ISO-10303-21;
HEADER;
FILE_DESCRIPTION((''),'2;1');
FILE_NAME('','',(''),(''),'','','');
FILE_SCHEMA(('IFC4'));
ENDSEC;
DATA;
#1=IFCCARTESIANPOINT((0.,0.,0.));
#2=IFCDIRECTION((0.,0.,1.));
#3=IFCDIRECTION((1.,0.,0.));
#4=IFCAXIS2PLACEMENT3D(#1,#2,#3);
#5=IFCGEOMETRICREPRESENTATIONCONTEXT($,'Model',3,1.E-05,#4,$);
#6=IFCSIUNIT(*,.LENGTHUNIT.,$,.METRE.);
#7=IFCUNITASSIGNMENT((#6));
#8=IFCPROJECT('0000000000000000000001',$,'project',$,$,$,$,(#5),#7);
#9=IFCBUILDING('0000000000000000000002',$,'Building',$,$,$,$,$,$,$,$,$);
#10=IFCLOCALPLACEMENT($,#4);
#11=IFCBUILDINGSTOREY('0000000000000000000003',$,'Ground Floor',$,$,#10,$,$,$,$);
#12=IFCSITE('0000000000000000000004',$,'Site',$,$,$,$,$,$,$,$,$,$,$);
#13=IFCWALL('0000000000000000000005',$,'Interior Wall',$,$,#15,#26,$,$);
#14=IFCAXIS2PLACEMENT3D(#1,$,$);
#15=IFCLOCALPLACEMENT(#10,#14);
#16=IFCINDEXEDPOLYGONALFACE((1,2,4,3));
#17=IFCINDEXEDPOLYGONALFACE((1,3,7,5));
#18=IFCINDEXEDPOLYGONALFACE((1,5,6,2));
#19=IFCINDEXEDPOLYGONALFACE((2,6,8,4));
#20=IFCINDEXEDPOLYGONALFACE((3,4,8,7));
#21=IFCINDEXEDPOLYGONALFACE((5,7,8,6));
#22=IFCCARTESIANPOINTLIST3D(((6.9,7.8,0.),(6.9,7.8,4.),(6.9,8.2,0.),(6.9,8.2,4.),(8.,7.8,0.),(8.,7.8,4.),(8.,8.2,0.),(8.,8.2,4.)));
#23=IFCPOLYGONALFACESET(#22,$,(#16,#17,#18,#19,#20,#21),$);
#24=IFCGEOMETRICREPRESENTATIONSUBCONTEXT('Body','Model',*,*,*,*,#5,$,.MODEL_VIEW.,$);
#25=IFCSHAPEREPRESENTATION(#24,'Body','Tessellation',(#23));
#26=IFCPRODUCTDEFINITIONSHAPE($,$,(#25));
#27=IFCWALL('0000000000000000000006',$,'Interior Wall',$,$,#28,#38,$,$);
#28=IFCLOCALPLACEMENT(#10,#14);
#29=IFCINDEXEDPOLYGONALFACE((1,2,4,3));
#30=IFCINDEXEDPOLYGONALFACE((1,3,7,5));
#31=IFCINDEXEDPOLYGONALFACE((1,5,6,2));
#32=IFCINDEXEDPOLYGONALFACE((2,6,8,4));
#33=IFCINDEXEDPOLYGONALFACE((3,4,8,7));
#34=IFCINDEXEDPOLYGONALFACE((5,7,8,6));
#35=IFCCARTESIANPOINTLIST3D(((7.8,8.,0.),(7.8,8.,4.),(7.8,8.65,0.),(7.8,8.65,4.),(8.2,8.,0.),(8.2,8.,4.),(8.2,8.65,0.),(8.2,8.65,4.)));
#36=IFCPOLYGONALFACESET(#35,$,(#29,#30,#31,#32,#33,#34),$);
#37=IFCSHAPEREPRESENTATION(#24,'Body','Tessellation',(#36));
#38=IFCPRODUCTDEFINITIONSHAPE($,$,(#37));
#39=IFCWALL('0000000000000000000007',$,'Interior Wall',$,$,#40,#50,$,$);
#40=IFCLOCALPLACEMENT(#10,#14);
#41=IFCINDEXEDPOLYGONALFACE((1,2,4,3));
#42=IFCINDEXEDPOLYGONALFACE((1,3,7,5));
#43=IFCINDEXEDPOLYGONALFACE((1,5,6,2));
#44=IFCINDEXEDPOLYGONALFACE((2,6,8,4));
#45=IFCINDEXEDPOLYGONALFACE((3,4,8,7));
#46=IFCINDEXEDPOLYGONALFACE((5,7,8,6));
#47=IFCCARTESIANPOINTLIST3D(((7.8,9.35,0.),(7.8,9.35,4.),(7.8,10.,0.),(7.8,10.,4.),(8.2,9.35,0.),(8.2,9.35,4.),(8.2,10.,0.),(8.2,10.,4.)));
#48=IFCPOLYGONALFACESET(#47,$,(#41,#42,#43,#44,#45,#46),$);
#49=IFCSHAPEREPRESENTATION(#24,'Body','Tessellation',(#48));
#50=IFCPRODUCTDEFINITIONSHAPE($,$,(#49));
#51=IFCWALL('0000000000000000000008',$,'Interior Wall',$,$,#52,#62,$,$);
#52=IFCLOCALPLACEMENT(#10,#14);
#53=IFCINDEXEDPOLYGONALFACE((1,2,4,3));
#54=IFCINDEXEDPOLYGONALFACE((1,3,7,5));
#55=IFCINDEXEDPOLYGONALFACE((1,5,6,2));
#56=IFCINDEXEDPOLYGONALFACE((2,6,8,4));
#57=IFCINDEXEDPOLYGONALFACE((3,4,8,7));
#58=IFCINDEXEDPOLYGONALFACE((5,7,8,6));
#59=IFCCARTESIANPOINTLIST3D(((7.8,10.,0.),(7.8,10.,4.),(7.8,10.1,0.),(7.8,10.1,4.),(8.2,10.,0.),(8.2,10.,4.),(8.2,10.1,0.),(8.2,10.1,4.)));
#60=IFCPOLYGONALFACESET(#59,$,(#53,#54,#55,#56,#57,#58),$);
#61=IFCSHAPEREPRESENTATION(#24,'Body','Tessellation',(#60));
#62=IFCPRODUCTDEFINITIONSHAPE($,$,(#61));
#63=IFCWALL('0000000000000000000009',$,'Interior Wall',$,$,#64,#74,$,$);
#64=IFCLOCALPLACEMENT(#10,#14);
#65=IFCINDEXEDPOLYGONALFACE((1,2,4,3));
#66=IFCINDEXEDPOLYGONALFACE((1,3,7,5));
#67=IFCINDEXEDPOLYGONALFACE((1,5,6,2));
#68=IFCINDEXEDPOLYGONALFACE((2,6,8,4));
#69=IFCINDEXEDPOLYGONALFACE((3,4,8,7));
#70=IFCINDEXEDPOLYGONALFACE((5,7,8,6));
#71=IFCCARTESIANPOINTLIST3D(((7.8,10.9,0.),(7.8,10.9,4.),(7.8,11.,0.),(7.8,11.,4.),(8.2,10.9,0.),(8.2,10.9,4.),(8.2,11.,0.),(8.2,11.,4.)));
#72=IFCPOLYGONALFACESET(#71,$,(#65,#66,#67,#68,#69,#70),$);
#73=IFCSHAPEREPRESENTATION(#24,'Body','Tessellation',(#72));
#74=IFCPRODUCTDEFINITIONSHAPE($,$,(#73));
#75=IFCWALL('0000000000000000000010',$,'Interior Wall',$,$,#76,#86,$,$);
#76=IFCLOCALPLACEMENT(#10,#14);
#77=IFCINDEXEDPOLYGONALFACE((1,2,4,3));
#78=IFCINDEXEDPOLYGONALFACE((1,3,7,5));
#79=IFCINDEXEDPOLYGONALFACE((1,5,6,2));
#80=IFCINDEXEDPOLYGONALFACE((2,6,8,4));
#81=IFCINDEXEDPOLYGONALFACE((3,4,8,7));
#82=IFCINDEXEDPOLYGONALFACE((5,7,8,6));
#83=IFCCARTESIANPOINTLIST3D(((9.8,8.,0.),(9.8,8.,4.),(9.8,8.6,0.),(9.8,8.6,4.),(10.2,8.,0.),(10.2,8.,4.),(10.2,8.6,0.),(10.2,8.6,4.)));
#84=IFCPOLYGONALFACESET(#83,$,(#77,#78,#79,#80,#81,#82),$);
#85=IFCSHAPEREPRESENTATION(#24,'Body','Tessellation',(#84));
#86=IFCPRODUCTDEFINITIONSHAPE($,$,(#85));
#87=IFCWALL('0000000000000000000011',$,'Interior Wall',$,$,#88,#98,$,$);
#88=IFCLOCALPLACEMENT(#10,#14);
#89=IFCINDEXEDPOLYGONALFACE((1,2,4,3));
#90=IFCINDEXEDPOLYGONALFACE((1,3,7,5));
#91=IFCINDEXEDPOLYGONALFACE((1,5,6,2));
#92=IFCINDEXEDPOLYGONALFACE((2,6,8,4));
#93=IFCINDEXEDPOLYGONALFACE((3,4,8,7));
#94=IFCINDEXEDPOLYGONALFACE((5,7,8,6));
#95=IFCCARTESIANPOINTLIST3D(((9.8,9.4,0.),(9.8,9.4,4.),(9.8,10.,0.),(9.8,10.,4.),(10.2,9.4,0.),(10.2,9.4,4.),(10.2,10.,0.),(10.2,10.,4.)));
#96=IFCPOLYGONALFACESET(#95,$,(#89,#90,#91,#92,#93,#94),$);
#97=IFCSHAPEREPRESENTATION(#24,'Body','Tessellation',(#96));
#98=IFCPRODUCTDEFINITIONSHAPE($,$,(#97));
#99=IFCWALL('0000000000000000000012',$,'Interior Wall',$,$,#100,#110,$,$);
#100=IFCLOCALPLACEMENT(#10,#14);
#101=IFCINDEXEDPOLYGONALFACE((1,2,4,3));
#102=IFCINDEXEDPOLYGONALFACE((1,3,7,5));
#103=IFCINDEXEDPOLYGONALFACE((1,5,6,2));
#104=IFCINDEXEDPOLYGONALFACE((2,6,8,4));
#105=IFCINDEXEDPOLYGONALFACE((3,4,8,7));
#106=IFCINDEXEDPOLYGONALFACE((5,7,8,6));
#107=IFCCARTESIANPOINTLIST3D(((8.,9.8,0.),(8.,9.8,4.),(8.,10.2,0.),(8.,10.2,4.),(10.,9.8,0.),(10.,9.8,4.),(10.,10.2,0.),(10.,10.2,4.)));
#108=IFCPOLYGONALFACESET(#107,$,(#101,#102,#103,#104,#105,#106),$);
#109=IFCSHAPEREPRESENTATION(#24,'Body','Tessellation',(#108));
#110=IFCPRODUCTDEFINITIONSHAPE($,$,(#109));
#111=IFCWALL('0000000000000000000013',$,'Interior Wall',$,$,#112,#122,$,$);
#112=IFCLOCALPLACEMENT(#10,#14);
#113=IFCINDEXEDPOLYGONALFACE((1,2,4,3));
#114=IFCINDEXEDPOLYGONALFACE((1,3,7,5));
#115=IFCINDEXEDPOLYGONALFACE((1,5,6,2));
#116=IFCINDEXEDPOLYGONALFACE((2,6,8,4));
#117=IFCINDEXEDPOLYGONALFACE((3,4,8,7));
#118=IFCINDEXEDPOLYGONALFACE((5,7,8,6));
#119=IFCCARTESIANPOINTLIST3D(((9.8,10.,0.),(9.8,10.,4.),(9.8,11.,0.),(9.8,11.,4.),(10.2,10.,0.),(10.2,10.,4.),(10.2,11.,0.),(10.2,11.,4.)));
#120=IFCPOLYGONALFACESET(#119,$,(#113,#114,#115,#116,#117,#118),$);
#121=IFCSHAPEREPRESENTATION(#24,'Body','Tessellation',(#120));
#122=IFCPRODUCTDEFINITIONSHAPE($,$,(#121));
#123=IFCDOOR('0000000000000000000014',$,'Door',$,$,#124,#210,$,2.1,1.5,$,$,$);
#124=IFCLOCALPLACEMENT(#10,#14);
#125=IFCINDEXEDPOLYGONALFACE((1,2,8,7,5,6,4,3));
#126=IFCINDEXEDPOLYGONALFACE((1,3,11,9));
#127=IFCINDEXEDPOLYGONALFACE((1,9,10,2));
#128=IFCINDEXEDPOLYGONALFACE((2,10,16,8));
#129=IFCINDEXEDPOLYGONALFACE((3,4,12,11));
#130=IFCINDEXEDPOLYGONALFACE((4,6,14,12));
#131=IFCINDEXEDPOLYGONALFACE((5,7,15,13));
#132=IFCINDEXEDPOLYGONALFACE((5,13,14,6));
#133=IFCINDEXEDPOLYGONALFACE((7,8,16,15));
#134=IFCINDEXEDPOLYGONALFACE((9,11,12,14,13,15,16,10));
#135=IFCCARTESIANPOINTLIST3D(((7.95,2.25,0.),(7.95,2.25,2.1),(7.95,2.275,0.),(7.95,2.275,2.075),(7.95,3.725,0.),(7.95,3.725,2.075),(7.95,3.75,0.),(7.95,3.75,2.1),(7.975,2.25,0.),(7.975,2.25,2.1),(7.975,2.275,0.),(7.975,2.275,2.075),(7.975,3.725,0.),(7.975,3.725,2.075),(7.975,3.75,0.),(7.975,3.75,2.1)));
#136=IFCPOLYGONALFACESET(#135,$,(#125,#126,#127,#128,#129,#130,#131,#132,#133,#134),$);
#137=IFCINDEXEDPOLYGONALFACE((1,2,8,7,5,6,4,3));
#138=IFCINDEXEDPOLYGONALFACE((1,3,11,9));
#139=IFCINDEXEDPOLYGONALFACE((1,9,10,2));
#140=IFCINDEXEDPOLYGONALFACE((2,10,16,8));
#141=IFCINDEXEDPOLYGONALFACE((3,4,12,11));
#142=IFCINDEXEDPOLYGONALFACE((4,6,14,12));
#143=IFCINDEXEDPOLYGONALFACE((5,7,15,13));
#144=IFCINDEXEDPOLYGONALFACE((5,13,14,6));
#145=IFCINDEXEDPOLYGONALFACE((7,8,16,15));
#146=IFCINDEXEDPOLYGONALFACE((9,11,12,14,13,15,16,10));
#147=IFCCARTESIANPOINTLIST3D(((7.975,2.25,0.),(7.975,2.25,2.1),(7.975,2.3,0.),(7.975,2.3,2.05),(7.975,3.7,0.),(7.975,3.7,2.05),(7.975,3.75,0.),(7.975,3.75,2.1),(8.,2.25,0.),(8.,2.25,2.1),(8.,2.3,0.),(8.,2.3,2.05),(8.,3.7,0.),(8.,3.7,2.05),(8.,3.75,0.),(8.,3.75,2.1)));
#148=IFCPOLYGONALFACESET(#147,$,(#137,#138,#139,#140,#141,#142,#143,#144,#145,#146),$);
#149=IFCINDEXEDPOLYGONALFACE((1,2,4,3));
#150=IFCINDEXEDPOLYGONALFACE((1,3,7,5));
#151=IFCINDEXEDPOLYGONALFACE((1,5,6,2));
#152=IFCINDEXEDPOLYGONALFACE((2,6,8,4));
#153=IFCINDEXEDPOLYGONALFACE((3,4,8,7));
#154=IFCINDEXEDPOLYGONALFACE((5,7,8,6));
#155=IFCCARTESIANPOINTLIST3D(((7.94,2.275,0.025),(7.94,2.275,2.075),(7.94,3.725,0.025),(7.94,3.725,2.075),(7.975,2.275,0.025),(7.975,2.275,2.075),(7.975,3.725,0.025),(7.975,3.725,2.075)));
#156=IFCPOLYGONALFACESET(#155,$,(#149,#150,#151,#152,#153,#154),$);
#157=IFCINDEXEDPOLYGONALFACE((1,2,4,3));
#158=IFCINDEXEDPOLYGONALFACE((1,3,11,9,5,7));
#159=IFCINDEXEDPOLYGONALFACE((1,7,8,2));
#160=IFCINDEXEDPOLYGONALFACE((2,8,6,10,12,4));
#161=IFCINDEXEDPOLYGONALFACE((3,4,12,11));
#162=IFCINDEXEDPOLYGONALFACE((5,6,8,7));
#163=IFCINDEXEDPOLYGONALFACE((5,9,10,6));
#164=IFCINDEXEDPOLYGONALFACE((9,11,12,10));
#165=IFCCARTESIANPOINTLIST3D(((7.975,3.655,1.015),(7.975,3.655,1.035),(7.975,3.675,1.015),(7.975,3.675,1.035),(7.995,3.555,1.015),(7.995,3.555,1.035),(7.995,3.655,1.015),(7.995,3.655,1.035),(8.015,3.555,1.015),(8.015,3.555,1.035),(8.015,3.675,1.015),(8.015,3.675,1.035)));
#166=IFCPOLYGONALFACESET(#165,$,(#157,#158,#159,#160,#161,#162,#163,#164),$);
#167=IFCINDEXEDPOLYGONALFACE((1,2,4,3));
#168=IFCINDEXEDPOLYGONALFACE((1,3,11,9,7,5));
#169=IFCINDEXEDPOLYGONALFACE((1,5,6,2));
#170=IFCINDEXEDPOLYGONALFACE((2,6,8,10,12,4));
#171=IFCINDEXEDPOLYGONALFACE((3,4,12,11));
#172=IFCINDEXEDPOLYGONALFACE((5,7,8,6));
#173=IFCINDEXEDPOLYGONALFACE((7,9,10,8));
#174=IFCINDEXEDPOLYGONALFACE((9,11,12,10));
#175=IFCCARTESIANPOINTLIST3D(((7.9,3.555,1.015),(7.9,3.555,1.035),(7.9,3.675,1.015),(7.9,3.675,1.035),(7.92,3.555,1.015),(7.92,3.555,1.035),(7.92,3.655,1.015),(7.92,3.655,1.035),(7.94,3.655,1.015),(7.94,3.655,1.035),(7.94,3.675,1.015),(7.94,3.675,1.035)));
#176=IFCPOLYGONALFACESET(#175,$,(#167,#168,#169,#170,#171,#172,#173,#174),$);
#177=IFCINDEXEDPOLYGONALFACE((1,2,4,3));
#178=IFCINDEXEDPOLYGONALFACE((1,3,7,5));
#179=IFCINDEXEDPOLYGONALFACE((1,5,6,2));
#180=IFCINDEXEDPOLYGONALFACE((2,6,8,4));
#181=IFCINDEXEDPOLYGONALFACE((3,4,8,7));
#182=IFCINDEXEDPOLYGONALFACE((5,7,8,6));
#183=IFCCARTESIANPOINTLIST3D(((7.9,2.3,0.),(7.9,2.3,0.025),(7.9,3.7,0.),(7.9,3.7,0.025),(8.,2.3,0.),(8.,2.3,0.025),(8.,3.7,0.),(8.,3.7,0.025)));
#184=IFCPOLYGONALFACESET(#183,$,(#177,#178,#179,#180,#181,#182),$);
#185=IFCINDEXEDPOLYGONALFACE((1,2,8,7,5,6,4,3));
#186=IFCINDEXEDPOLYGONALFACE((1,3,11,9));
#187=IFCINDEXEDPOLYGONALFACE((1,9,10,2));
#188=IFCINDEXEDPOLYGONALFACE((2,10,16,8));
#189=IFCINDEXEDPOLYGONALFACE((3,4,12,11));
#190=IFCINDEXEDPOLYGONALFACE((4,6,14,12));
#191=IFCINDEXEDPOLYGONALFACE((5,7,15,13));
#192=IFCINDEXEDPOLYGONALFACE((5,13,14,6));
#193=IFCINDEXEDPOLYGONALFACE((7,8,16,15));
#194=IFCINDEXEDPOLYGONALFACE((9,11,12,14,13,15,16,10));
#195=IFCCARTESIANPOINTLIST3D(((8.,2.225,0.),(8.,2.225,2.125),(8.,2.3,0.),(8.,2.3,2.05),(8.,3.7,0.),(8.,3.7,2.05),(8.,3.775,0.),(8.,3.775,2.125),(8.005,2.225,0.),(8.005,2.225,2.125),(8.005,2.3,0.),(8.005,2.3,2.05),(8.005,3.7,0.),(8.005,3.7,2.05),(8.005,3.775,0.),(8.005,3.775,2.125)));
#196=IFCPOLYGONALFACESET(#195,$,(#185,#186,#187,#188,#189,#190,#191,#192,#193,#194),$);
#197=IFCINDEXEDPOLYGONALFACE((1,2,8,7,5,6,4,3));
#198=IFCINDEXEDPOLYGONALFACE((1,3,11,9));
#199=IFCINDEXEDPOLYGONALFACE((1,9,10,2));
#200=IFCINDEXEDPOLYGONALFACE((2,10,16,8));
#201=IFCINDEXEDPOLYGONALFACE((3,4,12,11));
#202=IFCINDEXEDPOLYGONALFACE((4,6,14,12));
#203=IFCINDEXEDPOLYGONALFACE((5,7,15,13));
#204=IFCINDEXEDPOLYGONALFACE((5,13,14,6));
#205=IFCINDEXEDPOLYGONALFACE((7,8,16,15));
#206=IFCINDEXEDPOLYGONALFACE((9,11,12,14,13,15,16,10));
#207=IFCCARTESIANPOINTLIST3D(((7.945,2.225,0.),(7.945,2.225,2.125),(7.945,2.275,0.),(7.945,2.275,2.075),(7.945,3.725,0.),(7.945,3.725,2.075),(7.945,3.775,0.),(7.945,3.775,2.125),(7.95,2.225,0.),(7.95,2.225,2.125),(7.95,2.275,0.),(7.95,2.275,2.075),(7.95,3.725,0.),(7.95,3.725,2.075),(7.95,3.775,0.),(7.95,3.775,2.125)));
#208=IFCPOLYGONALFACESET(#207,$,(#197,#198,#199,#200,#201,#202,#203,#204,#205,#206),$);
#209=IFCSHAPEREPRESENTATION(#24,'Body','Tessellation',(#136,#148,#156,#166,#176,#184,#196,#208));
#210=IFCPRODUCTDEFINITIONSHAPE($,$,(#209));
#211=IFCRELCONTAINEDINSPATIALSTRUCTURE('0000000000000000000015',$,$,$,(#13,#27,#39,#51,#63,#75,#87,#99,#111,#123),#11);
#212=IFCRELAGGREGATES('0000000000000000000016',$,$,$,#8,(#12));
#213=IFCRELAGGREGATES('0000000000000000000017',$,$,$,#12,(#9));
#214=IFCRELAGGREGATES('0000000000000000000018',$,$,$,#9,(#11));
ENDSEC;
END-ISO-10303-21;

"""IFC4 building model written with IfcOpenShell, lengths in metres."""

from ifc_helpers import new_model, si_unit, frame, origin_with_axes, place, context, subcontext, project, spatial, line, indexed_curve, outline, extrude, element, save


model = new_model("IFC4")

# Units and contexts
model_context = context("Model", 3, precision=1e-05, world=origin_with_axes())
body_context = subcontext(model_context, "Body", "Model", "MODEL_VIEW")
ifc_project = project(units=[si_unit("LENGTHUNIT", "METRE")], contexts=[model_context])

# Site, building, storey
site = spatial("IfcSite", under=ifc_project, Name="Site")
building = spatial("IfcBuilding", under=site, Name="Building")
storey_placement = place(None, origin_with_axes())
storey = spatial("IfcBuildingStorey", under=building, at=storey_placement, Name="Ground Floor")

# Walls
wall_1_placement = place(storey_placement, frame((8.0, 8.0, 0.0), z_axis=(0.0, 0.0, 1.0), x_axis=(-1.0, 0.0, 0.0)))
element("IfcWall", 1, at=wall_1_placement, inside=storey, Name="Interior Wall", context=body_context, shape_type="SweptSolid", body=[
    extrude(outline(indexed_curve([(0.0, 0.0), (0.0, 0.4), (1.1, 0.4), (1.1, 0.0), (0.0, 0.0)], self_intersect=False)), frame((0.0, -0.2, 0.0), z_axis=(0.0, 0.0, 1.0), x_axis=(1.0, 0.0, 0.0)), (0.0, 0.0, 1.0), 4.0),
])
for number, where, z_axis, x_axis, name in (
    (2, (8.0, 8.0, 0.0), (0.0, 0.0, 1.0), (0.0, 1.0, 0.0), "Interior Wall"),
    (3, (8.0, 9.35, 0.0), (0.0, 0.0, 1.0), (0.0, 1.0, 0.0), "Interior Wall"),
):
    element("IfcWall", number, at=place(storey_placement, frame(where, z_axis=z_axis, x_axis=x_axis)), inside=storey, Name=name, context=body_context, shape_type="SweptSolid", body=[
        extrude(outline(indexed_curve([(0.0, 0.0), (0.0, 0.4), (0.65, 0.4), (0.65, 0.0), (0.0, 0.0)], self_intersect=False)), frame((0.0, -0.2, 0.0), z_axis=(0.0, 0.0, 1.0), x_axis=(1.0, 0.0, 0.0)), (0.0, 0.0, 1.0), 4.0),
    ])
for number, where, z_axis, x_axis, name in (
    (4, (8.0, 10.0, 0.0), (0.0, 0.0, 1.0), (0.0, 1.0, 0.0), "Interior Wall"),
    (5, (8.0, 10.9, 0.0), (0.0, 0.0, 1.0), (0.0, 1.0, 0.0), "Interior Wall"),
):
    element("IfcWall", number, at=place(storey_placement, frame(where, z_axis=z_axis, x_axis=x_axis)), inside=storey, Name=name, context=body_context, shape_type="SweptSolid", body=[
        extrude(outline(indexed_curve([(0.0, 0.0), (0.0, 0.4), (0.1, 0.4), (0.1, 0.0), (0.0, 0.0)], self_intersect=False)), frame((0.0, -0.2, 0.0), z_axis=(0.0, 0.0, 1.0), x_axis=(1.0, 0.0, 0.0)), (0.0, 0.0, 1.0), 4.0),
    ])
for number, where, z_axis, x_axis, name in (
    (6, (10.0, 8.0, 0.0), (0.0, 0.0, 1.0), (0.0, 1.0, 0.0), "Interior Wall"),
    (7, (10.0, 9.4, 0.0), (0.0, 0.0, 1.0), (0.0, 1.0, 0.0), "Interior Wall"),
):
    element("IfcWall", number, at=place(storey_placement, frame(where, z_axis=z_axis, x_axis=x_axis)), inside=storey, Name=name, context=body_context, shape_type="SweptSolid", body=[
        extrude(outline(indexed_curve([(0.0, 0.0), (0.0, 0.4), (0.6, 0.4), (0.6, 0.0), (0.0, 0.0)], self_intersect=False)), frame((0.0, -0.2, 0.0), z_axis=(0.0, 0.0, 1.0), x_axis=(1.0, 0.0, 0.0)), (0.0, 0.0, 1.0), 4.0),
    ])
wall_2_placement = place(storey_placement, frame((10.0, 10.0, 0.0), z_axis=(0.0, 0.0, 1.0), x_axis=(-1.0, 0.0, 0.0)))
element("IfcWall", 8, at=wall_2_placement, inside=storey, Name="Interior Wall", context=body_context, shape_type="SweptSolid", body=[
    extrude(outline(indexed_curve([(0.0, 0.0), (0.0, 0.4), (2.0, 0.4), (2.0, 0.0), (0.0, 0.0)], self_intersect=False)), frame((0.0, -0.2, 0.0), z_axis=(0.0, 0.0, 1.0), x_axis=(1.0, 0.0, 0.0)), (0.0, 0.0, 1.0), 4.0),
])
wall_3_placement = place(storey_placement, frame((10.0, 11.0, 0.0), z_axis=(0.0, 0.0, 1.0), x_axis=(0.0, -1.0, 0.0)))
element("IfcWall", 9, at=wall_3_placement, inside=storey, Name="Interior Wall", context=body_context, shape_type="SweptSolid", body=[
    extrude(outline(indexed_curve([(0.0, 0.0), (0.0, 0.4), (1.0, 0.4), (1.0, 0.0), (0.0, 0.0)], self_intersect=False)), frame((0.0, -0.2, 0.0), z_axis=(0.0, 0.0, 1.0), x_axis=(1.0, 0.0, 0.0)), (0.0, 0.0, 1.0), 4.0),
])

# Door
door_1_placement = place(storey_placement, frame((8.0, 2.25, 0.0), z_axis=(0.0, 0.0, 1.0), x_axis=(0.0, 1.0, 0.0)))
element("IfcDoor", 10, at=door_1_placement, inside=storey, Name="Door", OverallHeight=2.1, OverallWidth=1.5, context=body_context, shape_type="SweptSolid", body=[
    extrude(outline(indexed_curve([(0.0, 0.0), (0.0, 2.1), (1.5, 2.1), (1.5, 0.0), (1.475, 0.0), (1.475, 2.075), (0.025, 2.075), (0.025, 0.0)], segments=[line(1, 2, 3, 4, 5, 6, 7, 8, 1)])), frame((0.0, 0.025, 0.0), z_axis=(0.0, -1.0, 0.0), x_axis=(1.0, 0.0, 0.0)), (0.0, 0.0, -1.0), 0.025),
    extrude(outline(indexed_curve([(0.0, 0.0), (0.0, 2.1), (1.5, 2.1), (1.5, 0.0), (1.45, 0.0), (1.45, 2.05), (0.05, 2.05), (0.05, 0.0)], segments=[line(1, 2, 3, 4, 5, 6, 7, 8, 1)])), frame((0.0, 0.0, 0.0), z_axis=(0.0, -1.0, 0.0), x_axis=(1.0, 0.0, 0.0)), (0.0, 0.0, -1.0), 0.025),
    extrude(outline(indexed_curve([(0.0, 0.0), (1.45, 0.0), (1.45, 0.035), (0.0, 0.035)], segments=[line(1, 2, 3, 4, 1)])), frame((0.025, 0.025, 0.025), z_axis=(0.0, 0.0, 1.0), x_axis=(1.0, 0.0, 0.0)), (0.0, 0.0, 1.0), 2.05),
    extrude(outline(indexed_curve([(0.0, 0.0), (0.0, -0.04), (-0.12, -0.04), (-0.12, -0.02), (-0.02, -0.02), (-0.02, 0.0)], segments=[line(1, 2, 3, 4, 5, 6, 1)])), frame((1.425, 0.025, 1.015), z_axis=(0.0, 0.0, 1.0), x_axis=(1.0, 0.0, 0.0)), (0.0, 0.0, 1.0), 0.02),
    extrude(outline(indexed_curve([(0.0, 0.0), (0.0, 0.04), (-0.12, 0.04), (-0.12, 0.02), (-0.02, 0.02), (-0.02, 0.0)], segments=[line(1, 2, 3, 4, 5, 6, 1)])), frame((1.425, 0.06, 1.015), z_axis=(0.0, 0.0, 1.0), x_axis=(1.0, 0.0, 0.0)), (0.0, 0.0, 1.0), 0.02),
    extrude(outline(indexed_curve([(0.0, 0.0), (1.4, 0.0), (1.4, 0.1), (0.0, 0.1)], segments=[line(1, 2, 3, 4, 1)])), frame((0.05, 0.0, 0.0), z_axis=(0.0, 0.0, 1.0), x_axis=(1.0, 0.0, 0.0)), (0.0, 0.0, 1.0), 0.025),
    extrude(outline(indexed_curve([(0.0, 0.0), (0.0, 2.125), (1.55, 2.125), (1.55, 0.0), (1.475, 0.0), (1.475, 2.05), (0.075, 2.05), (0.075, 0.0)], segments=[line(1, 2, 3, 4, 5, 6, 7, 8, 1)])), frame((-0.025, -0.005, 0.0), z_axis=(0.0, -1.0, 0.0), x_axis=(1.0, 0.0, 0.0)), (0.0, 0.0, -1.0), 0.005),
    extrude(outline(indexed_curve([(0.0, 0.0), (0.0, 2.125), (1.55, 2.125), (1.55, 0.0), (1.5, 0.0), (1.5, 2.075), (0.05, 2.075), (0.05, 0.0)], segments=[line(1, 2, 3, 4, 5, 6, 7, 8, 1)])), frame((-0.025, 0.05, 0.0), z_axis=(0.0, -1.0, 0.0), x_axis=(1.0, 0.0, 0.0)), (0.0, 0.0, -1.0), 0.005),
])

save(model, "model.ifc")
